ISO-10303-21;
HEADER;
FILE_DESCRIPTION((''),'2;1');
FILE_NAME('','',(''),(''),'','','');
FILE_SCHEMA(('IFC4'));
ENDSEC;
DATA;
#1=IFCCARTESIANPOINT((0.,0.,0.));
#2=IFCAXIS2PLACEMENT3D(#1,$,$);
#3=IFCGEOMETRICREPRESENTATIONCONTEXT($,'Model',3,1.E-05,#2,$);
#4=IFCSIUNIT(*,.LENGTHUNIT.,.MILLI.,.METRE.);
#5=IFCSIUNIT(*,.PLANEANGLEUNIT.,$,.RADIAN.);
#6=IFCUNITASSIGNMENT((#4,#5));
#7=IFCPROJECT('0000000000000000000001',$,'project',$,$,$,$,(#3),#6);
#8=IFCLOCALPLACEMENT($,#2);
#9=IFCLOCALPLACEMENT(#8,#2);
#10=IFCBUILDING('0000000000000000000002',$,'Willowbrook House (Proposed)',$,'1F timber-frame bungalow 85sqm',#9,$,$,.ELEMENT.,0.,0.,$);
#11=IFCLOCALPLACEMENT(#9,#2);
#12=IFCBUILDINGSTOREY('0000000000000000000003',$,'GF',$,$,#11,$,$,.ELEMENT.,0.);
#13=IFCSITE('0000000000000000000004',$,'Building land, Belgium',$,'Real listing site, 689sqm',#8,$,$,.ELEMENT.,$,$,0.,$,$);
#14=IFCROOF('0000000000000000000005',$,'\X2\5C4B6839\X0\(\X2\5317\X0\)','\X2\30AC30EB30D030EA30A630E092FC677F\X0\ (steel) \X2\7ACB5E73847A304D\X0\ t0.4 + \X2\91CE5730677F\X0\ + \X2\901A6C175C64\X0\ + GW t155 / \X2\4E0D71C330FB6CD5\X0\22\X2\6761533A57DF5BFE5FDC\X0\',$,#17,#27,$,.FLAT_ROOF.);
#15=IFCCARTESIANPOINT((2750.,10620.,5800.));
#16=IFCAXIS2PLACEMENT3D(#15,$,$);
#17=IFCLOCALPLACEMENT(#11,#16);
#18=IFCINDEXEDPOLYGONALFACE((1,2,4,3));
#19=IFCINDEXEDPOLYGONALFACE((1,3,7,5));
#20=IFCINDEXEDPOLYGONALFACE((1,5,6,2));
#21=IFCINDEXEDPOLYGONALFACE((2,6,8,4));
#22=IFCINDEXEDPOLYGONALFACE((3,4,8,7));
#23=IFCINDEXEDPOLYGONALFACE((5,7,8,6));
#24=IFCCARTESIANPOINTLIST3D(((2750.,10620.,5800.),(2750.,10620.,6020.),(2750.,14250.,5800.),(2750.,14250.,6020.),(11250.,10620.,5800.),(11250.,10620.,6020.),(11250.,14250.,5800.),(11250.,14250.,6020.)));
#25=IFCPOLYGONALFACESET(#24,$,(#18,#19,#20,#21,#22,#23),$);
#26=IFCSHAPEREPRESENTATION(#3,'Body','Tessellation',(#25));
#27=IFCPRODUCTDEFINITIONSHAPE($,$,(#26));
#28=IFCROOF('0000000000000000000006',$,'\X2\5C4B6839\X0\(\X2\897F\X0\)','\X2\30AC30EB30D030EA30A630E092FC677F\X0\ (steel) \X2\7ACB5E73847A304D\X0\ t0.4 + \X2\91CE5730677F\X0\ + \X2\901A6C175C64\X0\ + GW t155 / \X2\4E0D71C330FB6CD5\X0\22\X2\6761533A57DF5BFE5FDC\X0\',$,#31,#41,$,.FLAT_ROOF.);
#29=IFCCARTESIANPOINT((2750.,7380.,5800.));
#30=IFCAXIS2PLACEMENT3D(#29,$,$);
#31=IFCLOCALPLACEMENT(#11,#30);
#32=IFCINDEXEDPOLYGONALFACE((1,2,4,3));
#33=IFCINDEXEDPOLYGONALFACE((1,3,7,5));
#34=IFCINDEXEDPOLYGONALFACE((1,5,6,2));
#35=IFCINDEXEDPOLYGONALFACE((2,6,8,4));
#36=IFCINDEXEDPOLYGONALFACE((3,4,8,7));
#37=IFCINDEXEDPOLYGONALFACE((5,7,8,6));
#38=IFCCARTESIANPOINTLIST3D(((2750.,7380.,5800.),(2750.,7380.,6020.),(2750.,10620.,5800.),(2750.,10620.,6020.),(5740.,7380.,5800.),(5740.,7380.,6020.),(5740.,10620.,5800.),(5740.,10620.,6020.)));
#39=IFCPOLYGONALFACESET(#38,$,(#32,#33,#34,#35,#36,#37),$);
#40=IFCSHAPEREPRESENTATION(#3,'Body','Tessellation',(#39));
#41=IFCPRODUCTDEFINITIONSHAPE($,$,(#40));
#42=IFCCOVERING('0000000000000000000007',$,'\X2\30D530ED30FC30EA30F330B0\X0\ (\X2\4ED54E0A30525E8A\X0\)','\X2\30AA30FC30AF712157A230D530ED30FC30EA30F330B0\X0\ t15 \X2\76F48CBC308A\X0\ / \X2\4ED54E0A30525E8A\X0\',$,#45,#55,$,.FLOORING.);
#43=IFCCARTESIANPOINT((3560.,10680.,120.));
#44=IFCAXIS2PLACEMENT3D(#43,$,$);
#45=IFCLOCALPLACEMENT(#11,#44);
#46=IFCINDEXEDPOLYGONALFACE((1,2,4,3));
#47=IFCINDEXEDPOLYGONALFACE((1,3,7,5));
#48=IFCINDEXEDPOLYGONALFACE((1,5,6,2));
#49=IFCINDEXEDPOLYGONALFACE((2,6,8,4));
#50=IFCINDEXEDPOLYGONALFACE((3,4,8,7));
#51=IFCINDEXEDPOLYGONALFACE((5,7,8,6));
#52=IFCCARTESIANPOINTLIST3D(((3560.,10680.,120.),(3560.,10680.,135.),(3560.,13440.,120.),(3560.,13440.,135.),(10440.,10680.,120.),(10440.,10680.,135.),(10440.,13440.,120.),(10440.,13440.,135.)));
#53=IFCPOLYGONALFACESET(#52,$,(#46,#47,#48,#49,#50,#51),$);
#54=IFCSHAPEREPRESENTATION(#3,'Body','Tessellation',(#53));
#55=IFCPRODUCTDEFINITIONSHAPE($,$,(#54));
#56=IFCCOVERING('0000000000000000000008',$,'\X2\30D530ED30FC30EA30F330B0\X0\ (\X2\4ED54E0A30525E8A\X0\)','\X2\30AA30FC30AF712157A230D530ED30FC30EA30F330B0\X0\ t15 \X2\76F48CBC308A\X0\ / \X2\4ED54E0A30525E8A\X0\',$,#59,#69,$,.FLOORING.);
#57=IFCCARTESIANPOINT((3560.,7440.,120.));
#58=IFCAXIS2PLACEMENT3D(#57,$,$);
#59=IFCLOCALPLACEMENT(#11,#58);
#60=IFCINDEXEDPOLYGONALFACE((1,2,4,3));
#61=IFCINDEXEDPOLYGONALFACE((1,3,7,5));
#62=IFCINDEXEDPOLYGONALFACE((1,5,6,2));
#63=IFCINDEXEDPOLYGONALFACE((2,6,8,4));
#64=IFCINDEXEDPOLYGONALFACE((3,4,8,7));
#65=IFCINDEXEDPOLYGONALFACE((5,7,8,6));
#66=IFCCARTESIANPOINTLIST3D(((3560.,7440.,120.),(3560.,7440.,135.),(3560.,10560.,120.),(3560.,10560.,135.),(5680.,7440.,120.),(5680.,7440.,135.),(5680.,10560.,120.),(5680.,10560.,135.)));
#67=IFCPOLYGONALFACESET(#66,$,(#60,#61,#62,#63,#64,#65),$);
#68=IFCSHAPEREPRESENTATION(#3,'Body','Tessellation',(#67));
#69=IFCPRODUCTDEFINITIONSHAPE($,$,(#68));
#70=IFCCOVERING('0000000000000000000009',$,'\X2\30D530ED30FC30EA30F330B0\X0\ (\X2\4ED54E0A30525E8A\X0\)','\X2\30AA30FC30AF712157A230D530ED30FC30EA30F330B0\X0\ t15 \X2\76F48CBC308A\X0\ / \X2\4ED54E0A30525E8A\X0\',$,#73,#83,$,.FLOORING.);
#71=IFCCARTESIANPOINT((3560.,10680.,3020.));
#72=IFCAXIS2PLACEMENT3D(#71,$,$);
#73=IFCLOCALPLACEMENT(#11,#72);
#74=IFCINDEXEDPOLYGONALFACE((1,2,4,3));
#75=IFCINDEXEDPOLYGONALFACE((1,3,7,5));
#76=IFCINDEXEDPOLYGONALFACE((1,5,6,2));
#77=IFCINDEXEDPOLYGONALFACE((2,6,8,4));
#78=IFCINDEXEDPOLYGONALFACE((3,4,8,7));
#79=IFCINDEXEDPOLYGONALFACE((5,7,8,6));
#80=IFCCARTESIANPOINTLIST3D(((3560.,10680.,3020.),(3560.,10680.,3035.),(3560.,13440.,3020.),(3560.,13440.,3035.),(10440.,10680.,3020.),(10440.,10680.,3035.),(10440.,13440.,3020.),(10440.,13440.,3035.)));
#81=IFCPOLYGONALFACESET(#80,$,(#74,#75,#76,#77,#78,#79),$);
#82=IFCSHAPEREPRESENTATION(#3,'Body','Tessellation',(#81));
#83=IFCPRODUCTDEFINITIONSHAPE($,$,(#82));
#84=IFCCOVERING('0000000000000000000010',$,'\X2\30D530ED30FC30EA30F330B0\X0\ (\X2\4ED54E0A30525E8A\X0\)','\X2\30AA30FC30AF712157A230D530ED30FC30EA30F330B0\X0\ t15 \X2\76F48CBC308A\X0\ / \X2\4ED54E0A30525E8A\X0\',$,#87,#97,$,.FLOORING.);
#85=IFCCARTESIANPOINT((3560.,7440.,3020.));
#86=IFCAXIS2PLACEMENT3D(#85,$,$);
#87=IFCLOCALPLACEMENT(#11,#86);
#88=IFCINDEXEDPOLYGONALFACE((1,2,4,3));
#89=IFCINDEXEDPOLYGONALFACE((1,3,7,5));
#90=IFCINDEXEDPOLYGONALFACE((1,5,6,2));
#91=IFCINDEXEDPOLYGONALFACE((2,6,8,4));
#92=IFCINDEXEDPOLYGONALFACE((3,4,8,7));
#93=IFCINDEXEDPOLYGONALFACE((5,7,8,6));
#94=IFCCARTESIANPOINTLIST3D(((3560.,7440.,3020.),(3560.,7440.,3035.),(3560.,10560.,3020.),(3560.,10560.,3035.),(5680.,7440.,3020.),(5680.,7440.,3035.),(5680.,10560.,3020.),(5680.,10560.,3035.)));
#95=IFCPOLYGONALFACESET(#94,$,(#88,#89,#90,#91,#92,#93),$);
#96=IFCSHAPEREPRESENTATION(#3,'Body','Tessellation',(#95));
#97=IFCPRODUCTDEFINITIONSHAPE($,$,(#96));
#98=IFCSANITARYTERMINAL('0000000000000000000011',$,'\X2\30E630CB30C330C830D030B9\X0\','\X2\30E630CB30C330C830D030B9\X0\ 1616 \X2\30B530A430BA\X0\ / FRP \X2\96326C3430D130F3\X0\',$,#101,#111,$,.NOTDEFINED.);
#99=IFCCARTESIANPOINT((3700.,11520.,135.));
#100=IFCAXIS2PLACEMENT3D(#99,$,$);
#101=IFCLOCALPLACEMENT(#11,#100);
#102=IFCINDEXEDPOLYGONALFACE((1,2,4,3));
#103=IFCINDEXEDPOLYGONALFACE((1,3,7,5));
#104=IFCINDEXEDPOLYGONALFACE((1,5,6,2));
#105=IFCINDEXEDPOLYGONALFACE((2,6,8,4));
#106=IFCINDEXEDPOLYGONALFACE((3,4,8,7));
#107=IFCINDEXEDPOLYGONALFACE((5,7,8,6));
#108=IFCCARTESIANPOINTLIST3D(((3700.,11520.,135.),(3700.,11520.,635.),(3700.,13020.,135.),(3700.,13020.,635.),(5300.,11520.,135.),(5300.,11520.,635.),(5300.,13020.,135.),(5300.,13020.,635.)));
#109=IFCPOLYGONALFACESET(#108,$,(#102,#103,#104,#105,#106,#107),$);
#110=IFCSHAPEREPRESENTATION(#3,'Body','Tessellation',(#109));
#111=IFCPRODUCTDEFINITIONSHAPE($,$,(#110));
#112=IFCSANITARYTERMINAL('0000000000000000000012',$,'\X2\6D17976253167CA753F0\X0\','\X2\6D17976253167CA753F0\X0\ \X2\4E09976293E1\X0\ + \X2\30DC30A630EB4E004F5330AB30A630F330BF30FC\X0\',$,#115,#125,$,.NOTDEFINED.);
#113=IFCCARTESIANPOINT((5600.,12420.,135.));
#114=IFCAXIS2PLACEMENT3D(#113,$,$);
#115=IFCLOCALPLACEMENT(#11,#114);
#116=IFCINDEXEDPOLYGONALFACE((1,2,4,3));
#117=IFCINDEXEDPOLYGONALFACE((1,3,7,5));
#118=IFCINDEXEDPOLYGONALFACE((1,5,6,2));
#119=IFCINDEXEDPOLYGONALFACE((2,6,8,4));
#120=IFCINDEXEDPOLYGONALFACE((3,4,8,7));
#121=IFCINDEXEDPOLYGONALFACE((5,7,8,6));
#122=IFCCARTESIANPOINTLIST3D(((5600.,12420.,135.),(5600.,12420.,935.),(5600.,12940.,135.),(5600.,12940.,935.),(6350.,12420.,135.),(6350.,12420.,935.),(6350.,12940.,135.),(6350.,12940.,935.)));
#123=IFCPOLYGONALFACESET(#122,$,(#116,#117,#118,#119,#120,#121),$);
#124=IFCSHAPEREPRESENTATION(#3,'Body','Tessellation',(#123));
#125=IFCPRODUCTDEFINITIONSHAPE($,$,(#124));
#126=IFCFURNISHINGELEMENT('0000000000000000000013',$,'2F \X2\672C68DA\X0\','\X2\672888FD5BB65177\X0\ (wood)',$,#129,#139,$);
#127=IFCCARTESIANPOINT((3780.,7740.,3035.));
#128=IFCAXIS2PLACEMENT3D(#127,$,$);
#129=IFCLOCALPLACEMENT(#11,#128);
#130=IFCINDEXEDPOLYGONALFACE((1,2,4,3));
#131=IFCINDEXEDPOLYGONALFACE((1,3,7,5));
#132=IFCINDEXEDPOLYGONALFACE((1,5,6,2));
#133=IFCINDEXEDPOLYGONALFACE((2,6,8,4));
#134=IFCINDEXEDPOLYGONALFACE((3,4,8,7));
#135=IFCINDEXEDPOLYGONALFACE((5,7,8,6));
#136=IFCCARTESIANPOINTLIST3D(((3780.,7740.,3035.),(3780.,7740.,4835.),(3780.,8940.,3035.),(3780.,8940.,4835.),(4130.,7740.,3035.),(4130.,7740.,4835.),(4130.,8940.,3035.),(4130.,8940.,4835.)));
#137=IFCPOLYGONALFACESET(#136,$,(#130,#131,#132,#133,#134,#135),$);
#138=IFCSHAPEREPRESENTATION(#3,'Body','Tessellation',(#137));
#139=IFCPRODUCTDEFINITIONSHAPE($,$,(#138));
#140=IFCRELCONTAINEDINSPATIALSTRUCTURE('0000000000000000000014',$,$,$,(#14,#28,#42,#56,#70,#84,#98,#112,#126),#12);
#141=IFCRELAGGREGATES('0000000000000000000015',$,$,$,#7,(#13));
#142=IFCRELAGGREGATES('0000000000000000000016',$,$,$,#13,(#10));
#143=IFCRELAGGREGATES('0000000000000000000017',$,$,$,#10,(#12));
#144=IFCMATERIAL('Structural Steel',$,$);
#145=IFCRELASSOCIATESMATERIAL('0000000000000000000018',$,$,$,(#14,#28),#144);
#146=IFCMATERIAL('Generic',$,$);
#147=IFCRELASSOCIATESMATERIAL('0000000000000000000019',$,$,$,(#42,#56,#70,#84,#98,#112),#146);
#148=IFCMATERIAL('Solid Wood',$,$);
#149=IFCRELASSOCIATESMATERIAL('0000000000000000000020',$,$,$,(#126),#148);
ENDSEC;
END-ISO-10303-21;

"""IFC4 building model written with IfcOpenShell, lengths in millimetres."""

from ifc_helpers import new_model, si_unit, frame, frame_2d, origin, place, context, project, spatial, rectangle, extrude, material, element, save


model = new_model("IFC4")

# Units and contexts
model_context = context("Model", 3, precision=1e-05, world=origin())
ifc_project = project(units=[si_unit("LENGTHUNIT", "METRE", prefix="MILLI"), si_unit("PLANEANGLEUNIT", "RADIAN")], contexts=[model_context])

# Site, building, storey
site_placement = place(None, origin())
site = spatial("IfcSite", under=ifc_project, at=site_placement, Name="Building land, Belgium", ObjectType="Real listing site, 689sqm", CompositionType="ELEMENT", RefElevation=0.0)
building_placement = place(site_placement, origin())
building = spatial("IfcBuilding", under=site, at=building_placement, Name="Willowbrook House (Proposed)", ObjectType="1F timber-frame bungalow 85sqm", CompositionType="ELEMENT", ElevationOfRefHeight=0.0, ElevationOfTerrain=0.0)
storey_placement = place(building_placement, origin())
storey = spatial("IfcBuildingStorey", under=building, at=storey_placement, Name="GF", CompositionType="ELEMENT", Elevation=0.0)

# Shared definitions
ifc_material_1 = material(Name="Solid Wood")

# Roofs
ifc_material_2 = material(Name="Structural Steel")
for number, where, name in (
    (1, (2750.0, 10620.0, 5800.0), "屋根(北)"),
):
    element("IfcRoof", number, at=place(storey_placement, frame(where)), inside=storey, material=ifc_material_2, Name=name, Description="ガルバリウム鋼板 (steel) 立平葺き t0.4 + 野地板 + 通気層 + GW t155 / 不燃・法22条区域対応", PredefinedType="FLAT_ROOF", context=model_context, shape_type="SweptSolid", body=[
        extrude(rectangle(XDim=8500.0, YDim=3630.0, at=frame_2d((4250.0, 1815.0))), frame((2750.0, 10620.0, 5800.0)), (0.0, 0.0, 1.0), 220.0),
    ])
roof_placement = place(storey_placement, frame((2750.0, 7380.0, 5800.0)))
element("IfcRoof", 2, at=roof_placement, inside=storey, material=ifc_material_2, Name="屋根(西)", Description="ガルバリウム鋼板 (steel) 立平葺き t0.4 + 野地板 + 通気層 + GW t155 / 不燃・法22条区域対応", PredefinedType="FLAT_ROOF", context=model_context, shape_type="SweptSolid", body=[
    extrude(rectangle(XDim=2990.0, YDim=3240.0, at=frame_2d((1495.0, 1620.0))), frame((2750.0, 7380.0, 5800.0)), (0.0, 0.0, 1.0), 220.0),
])

# Coverings
ifc_material_3 = material(Name="Generic")
covering_1_placement = place(storey_placement, frame((3560.0, 10680.0, 120.0)))
element("IfcCovering", 3, at=covering_1_placement, inside=storey, material=ifc_material_3, Name="フローリング (仕上げ床)", Description="オーク無垢フローリング t15 直貼り / 仕上げ床", PredefinedType="FLOORING", context=model_context, shape_type="SweptSolid", body=[
    extrude(rectangle(XDim=6880.0, YDim=2760.0, at=frame_2d((3440.0, 1380.0))), frame((3560.0, 10680.0, 120.0)), (0.0, 0.0, 1.0), 15.0),
])
covering_2_placement = place(storey_placement, frame((3560.0, 7440.0, 120.0)))
element("IfcCovering", 4, at=covering_2_placement, inside=storey, material=ifc_material_3, Name="フローリング (仕上げ床)", Description="オーク無垢フローリング t15 直貼り / 仕上げ床", PredefinedType="FLOORING", context=model_context, shape_type="SweptSolid", body=[
    extrude(rectangle(XDim=2120.0, YDim=3120.0, at=frame_2d((1060.0, 1560.0))), frame((3560.0, 7440.0, 120.0)), (0.0, 0.0, 1.0), 15.0),
])
covering_3_placement = place(storey_placement, frame((3560.0, 10680.0, 3020.0)))
element("IfcCovering", 5, at=covering_3_placement, inside=storey, material=ifc_material_3, Name="フローリング (仕上げ床)", Description="オーク無垢フローリング t15 直貼り / 仕上げ床", PredefinedType="FLOORING", context=model_context, shape_type="SweptSolid", body=[
    extrude(rectangle(XDim=6880.0, YDim=2760.0, at=frame_2d((3440.0, 1380.0))), frame((3560.0, 10680.0, 3020.0)), (0.0, 0.0, 1.0), 15.0),
])
covering_4_placement = place(storey_placement, frame((3560.0, 7440.0, 3020.0)))
element("IfcCovering", 6, at=covering_4_placement, inside=storey, material=ifc_material_3, Name="フローリング (仕上げ床)", Description="オーク無垢フローリング t15 直貼り / 仕上げ床", PredefinedType="FLOORING", context=model_context, shape_type="SweptSolid", body=[
    extrude(rectangle(XDim=2120.0, YDim=3120.0, at=frame_2d((1060.0, 1560.0))), frame((3560.0, 7440.0, 3020.0)), (0.0, 0.0, 1.0), 15.0),
])

# Sanitary terminals
sanitary_terminal_1_placement = place(storey_placement, frame((3700.0, 11520.0, 135.0)))
element("IfcSanitaryTerminal", 7, at=sanitary_terminal_1_placement, inside=storey, material=ifc_material_3, Name="ユニットバス", Description="ユニットバス 1616 サイズ / FRP 防水パン", PredefinedType="NOTDEFINED", context=model_context, shape_type="SweptSolid", body=[
    extrude(rectangle(XDim=1600.0, YDim=1500.0, at=frame_2d((800.0, 750.0))), frame((3700.0, 11520.0, 135.0)), (0.0, 0.0, 1.0), 500.0),
])
sanitary_terminal_2_placement = place(storey_placement, frame((5600.0, 12420.0, 135.0)))
element("IfcSanitaryTerminal", 8, at=sanitary_terminal_2_placement, inside=storey, material=ifc_material_3, Name="洗面化粧台", Description="洗面化粧台 三面鏡 + ボウル一体カウンター", PredefinedType="NOTDEFINED", context=model_context, shape_type="SweptSolid", body=[
    extrude(rectangle(XDim=750.0, YDim=520.0, at=frame_2d((375.0, 260.0))), frame((5600.0, 12420.0, 135.0)), (0.0, 0.0, 1.0), 800.0),
])

# Furnishing element
furnishing_placement = place(storey_placement, frame((3780.0, 7740.0, 3035.0)))
element("IfcFurnishingElement", 9, at=furnishing_placement, inside=storey, material=ifc_material_1, Name="2F 本棚", Description="木製家具 (wood)", context=model_context, shape_type="SweptSolid", body=[
    extrude(rectangle(XDim=350.0, YDim=1200.0, at=frame_2d((175.0, 600.0))), frame((3780.0, 7740.0, 3035.0)), (0.0, 0.0, 1.0), 1800.0),
])

save(model, "model.ifc")
